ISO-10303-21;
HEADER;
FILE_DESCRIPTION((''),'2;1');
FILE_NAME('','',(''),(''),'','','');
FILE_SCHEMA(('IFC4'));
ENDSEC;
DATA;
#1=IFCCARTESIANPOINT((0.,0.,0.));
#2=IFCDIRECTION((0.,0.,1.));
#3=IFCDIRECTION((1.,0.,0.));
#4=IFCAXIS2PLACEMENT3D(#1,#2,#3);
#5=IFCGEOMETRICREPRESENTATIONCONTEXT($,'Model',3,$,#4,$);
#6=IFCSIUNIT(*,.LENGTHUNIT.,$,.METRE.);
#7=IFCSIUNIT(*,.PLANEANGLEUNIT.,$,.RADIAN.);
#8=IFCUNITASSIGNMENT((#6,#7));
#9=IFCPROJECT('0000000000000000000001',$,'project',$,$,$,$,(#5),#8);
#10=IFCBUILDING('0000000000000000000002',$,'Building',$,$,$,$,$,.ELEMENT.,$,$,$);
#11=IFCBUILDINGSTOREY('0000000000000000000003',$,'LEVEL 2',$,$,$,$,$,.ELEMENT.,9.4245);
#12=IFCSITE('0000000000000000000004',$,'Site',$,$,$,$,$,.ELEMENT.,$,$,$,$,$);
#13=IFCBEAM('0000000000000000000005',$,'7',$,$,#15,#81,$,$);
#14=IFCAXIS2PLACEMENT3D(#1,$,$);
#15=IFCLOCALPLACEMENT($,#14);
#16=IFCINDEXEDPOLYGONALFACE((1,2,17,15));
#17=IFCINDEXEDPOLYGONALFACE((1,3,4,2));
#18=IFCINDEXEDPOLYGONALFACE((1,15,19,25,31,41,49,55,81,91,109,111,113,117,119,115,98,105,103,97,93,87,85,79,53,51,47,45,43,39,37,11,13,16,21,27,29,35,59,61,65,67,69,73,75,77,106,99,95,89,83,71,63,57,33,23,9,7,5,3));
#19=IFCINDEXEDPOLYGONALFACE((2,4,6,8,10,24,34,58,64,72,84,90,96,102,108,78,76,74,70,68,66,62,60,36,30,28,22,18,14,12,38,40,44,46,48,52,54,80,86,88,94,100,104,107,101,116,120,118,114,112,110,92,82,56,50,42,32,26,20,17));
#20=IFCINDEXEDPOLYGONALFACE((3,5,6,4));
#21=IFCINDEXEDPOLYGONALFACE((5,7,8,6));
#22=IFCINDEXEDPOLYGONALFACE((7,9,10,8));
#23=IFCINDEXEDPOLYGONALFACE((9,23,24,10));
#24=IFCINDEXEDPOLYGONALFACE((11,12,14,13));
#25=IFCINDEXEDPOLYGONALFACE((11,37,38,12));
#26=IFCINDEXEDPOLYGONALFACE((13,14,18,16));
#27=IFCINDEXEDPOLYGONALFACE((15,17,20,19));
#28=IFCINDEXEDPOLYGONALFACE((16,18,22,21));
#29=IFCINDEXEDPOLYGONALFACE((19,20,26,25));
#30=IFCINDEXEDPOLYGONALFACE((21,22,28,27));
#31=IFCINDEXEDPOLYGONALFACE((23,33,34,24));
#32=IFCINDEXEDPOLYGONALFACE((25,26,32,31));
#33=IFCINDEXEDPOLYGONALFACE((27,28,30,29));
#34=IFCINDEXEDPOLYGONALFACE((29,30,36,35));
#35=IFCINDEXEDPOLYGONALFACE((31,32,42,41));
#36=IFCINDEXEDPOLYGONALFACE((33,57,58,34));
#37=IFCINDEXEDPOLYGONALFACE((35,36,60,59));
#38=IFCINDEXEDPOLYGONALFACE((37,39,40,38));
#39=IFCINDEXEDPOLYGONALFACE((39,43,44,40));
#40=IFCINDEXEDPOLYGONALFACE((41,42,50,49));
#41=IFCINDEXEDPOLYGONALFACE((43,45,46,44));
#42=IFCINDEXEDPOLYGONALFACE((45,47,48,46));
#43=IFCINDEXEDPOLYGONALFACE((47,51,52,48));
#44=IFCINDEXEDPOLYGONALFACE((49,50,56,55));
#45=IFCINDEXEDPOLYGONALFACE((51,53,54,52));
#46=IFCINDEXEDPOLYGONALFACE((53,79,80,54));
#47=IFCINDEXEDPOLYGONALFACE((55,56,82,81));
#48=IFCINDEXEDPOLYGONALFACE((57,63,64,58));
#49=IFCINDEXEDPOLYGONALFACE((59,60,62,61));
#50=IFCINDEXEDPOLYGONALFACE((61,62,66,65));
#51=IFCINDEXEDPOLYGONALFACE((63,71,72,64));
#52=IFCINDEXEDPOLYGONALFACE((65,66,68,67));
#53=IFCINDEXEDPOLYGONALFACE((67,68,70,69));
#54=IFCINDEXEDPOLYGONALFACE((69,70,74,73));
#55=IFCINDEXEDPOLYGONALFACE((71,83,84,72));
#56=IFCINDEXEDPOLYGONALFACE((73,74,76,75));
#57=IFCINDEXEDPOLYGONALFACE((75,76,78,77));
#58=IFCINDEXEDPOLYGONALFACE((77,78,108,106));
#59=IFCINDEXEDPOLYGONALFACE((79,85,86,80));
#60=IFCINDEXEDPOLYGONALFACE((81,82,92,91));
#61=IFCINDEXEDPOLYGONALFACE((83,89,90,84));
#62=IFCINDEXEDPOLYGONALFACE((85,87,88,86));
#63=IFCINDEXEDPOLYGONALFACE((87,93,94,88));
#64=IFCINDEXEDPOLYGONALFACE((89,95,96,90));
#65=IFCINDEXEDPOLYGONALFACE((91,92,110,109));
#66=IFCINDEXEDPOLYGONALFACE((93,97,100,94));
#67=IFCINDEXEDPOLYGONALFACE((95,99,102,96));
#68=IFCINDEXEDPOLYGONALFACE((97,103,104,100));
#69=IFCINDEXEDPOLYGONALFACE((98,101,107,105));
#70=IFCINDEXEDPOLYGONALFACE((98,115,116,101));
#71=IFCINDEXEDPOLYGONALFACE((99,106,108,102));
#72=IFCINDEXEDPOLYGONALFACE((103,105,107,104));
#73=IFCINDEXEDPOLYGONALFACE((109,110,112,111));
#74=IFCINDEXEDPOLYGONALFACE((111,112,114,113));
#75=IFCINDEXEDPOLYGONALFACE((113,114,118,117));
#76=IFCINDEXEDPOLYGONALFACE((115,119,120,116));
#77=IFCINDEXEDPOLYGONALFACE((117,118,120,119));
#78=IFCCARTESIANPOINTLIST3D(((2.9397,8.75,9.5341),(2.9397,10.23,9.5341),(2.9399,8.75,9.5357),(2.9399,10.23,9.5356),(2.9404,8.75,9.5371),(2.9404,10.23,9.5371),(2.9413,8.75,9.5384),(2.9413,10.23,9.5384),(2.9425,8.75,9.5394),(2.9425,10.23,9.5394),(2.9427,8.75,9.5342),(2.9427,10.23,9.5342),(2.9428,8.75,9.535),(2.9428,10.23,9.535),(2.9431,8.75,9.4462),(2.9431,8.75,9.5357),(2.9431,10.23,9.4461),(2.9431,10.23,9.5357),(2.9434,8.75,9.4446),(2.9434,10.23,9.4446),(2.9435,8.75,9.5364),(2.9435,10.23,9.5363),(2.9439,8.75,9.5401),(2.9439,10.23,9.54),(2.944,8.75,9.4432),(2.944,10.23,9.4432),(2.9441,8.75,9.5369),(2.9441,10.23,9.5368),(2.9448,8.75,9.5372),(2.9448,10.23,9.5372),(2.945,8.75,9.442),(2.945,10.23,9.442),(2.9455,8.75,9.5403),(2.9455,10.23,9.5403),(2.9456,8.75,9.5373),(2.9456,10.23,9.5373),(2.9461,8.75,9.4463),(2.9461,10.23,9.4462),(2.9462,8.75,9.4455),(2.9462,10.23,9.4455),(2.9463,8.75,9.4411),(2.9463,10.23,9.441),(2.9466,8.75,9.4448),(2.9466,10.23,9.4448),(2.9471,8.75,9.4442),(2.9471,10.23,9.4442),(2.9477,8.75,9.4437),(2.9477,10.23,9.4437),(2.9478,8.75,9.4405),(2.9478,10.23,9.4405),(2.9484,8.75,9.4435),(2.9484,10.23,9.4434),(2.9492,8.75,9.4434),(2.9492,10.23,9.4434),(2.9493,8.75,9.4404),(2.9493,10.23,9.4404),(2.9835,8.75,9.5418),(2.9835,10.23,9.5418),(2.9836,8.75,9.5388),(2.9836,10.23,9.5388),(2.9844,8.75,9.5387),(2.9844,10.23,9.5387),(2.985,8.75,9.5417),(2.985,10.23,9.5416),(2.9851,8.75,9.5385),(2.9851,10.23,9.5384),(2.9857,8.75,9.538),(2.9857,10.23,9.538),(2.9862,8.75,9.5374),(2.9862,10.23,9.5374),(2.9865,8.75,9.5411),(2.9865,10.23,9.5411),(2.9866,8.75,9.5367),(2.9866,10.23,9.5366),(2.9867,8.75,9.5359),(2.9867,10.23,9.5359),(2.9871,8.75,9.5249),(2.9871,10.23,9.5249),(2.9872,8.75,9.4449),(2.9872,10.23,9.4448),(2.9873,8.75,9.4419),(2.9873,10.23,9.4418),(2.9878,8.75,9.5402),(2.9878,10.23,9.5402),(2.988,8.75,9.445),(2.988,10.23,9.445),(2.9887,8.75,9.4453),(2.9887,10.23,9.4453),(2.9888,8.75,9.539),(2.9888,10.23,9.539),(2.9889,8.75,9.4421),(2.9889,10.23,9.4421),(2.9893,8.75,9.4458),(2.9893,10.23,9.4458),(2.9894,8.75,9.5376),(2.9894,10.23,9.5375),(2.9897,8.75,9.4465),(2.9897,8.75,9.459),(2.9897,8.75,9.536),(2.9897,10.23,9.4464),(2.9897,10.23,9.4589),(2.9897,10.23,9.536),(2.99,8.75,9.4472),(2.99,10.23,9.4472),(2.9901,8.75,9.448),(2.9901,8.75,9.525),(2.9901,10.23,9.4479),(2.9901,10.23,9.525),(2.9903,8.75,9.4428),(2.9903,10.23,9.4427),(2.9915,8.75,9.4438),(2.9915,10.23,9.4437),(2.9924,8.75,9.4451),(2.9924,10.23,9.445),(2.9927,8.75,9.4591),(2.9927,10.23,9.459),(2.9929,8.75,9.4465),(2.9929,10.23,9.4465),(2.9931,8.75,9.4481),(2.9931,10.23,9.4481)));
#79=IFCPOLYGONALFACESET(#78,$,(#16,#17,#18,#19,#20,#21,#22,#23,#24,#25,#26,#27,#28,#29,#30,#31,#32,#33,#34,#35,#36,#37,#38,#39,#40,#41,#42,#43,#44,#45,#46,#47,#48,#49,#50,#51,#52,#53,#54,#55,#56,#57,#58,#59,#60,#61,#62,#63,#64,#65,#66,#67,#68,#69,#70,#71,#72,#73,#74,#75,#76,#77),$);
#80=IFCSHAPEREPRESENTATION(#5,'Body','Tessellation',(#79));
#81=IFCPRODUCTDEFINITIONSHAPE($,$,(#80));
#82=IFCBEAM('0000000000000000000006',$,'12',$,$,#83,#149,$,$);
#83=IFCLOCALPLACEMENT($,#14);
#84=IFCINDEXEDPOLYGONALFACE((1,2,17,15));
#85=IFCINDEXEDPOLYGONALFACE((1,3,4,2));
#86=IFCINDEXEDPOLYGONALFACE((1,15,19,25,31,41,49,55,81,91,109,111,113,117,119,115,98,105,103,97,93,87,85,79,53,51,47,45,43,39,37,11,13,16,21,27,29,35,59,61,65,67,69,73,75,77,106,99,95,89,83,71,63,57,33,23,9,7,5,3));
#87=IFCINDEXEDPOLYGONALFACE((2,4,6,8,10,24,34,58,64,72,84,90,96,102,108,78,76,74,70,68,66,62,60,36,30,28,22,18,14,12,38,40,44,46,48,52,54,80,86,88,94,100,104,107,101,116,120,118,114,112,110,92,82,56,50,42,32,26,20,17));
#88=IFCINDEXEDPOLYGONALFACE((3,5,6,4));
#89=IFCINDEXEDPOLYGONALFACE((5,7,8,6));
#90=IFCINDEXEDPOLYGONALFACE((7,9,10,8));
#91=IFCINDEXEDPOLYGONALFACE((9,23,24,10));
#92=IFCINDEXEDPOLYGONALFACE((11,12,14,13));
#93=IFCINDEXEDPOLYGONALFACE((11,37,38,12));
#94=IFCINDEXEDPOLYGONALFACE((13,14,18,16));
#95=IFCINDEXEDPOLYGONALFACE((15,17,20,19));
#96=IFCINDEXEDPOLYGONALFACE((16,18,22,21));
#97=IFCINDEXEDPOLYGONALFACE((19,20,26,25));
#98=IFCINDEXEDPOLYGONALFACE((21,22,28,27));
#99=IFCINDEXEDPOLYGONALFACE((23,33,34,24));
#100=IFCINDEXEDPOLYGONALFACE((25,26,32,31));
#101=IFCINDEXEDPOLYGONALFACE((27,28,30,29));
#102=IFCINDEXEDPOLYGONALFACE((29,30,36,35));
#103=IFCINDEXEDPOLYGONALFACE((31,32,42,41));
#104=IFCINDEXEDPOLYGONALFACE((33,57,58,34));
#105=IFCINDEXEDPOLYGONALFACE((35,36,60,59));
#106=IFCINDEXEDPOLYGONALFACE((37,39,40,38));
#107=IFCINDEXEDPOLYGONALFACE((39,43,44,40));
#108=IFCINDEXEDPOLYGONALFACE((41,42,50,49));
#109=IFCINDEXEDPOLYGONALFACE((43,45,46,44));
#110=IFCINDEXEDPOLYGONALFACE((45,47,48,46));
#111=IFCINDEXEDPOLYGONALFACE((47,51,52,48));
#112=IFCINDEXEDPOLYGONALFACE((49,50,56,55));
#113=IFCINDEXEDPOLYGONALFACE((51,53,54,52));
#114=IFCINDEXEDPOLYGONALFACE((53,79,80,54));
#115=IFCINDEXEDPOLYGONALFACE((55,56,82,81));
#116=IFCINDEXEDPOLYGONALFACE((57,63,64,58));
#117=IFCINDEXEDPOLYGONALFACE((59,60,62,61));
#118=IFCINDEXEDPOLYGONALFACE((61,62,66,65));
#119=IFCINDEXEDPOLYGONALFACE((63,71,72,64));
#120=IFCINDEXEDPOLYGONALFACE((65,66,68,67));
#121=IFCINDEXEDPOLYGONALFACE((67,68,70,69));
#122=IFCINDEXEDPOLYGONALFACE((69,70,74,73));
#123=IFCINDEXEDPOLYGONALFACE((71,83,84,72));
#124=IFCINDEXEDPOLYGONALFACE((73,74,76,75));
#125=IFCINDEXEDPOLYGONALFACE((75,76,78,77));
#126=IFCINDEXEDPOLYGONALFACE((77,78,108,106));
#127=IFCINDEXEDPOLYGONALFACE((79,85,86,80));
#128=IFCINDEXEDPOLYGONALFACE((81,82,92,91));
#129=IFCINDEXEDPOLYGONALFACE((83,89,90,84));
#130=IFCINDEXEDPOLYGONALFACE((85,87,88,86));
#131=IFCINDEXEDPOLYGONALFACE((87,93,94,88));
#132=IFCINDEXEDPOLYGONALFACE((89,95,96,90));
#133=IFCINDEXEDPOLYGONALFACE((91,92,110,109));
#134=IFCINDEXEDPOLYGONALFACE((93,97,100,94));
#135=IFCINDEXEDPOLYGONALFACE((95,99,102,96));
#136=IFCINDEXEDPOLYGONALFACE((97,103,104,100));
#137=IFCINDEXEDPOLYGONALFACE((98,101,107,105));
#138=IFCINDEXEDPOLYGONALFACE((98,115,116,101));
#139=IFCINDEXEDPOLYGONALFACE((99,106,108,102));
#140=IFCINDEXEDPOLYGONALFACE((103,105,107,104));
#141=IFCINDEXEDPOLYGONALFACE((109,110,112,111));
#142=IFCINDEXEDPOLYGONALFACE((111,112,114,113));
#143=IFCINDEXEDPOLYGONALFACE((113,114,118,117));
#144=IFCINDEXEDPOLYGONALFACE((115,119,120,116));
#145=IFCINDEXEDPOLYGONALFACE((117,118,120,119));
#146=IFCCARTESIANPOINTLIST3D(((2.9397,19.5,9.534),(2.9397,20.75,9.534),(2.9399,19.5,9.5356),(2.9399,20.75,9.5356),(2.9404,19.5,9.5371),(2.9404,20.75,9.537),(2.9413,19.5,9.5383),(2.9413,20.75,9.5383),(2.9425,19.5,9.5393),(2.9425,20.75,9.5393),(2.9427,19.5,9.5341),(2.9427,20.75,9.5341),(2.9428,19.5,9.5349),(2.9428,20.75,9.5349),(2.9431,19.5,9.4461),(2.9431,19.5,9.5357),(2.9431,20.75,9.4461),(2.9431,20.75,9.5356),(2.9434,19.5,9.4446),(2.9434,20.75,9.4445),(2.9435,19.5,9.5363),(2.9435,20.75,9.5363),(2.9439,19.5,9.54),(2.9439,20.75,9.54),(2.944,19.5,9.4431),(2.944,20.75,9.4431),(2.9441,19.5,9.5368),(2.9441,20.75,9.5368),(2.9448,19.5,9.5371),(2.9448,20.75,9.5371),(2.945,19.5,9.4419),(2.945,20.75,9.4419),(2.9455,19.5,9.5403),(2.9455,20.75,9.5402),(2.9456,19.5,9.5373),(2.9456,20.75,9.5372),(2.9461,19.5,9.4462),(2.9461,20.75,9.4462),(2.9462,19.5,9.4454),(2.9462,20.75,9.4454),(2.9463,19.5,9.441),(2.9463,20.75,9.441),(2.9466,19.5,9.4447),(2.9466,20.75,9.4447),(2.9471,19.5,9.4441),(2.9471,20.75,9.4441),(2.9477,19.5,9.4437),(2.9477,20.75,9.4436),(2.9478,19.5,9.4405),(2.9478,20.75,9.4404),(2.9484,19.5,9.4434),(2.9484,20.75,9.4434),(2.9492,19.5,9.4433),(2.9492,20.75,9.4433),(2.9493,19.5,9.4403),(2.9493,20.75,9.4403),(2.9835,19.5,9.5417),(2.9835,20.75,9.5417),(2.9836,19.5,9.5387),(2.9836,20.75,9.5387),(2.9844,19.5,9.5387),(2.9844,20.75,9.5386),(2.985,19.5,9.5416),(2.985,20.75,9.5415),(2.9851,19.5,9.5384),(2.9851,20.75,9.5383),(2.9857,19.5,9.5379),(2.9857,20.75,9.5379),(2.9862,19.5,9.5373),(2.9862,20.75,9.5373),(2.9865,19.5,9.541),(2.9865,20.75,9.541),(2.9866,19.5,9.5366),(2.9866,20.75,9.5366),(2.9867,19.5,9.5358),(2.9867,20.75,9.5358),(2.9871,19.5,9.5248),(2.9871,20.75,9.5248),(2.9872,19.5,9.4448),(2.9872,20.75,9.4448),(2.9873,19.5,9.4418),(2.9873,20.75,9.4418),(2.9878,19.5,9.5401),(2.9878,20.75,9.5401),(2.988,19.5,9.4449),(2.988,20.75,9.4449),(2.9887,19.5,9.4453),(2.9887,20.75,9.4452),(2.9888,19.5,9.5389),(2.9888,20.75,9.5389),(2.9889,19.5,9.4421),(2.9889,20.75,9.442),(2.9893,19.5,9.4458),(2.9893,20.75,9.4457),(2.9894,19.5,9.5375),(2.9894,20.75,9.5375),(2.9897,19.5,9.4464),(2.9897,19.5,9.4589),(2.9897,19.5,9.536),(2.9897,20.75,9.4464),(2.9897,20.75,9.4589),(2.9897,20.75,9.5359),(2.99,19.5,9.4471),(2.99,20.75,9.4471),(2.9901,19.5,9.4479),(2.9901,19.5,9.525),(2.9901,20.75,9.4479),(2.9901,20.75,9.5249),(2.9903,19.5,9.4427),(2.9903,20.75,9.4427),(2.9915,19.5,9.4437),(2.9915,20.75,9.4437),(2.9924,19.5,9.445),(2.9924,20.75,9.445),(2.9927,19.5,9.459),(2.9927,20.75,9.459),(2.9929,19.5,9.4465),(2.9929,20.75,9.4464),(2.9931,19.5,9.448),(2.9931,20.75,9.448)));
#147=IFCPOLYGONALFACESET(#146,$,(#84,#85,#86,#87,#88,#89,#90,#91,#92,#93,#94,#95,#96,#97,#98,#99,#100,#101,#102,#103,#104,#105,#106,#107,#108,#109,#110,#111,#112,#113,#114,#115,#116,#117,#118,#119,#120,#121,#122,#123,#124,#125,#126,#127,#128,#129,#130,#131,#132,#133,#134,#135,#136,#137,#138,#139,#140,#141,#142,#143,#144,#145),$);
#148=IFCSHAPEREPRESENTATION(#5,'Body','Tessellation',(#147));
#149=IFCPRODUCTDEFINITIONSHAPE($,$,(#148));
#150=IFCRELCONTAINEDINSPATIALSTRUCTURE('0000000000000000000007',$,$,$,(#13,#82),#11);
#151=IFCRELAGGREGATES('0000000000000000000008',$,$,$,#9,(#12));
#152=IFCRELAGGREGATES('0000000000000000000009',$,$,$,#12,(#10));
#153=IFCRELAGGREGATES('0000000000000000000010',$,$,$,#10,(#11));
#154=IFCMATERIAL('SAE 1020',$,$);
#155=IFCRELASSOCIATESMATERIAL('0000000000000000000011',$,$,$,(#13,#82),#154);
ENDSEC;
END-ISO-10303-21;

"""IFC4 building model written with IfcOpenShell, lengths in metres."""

from ifc_helpers import new_model, si_unit, frame, origin_with_axes, origin_2d_with_axis, place, context, project, spatial, c_section, extrude, material, material_profile, profile_set, profile_usage, element, save


model = new_model("IFC4")

# Units and contexts
model_context = context("Model", 3, world=origin_with_axes())
ifc_project = project(units=[si_unit("LENGTHUNIT", "METRE"), si_unit("PLANEANGLEUNIT", "RADIAN")], contexts=[model_context])

# Site, building, storey
site = spatial("IfcSite", under=ifc_project, Name="Site", CompositionType="ELEMENT")
building = spatial("IfcBuilding", under=site, Name="Building", CompositionType="ELEMENT")
storey = spatial("IfcBuildingStorey", under=building, Name="LEVEL 2", CompositionType="ELEMENT", Elevation=9.4245)

# Beams
ifc_material = material(Name="SAE 1020")
ifc_material_profile_1 = material_profile(ifc_material, c_section(Depth=0.1, Width=0.05, WallThickness=0.003, Girth=0.017, InternalFilletRadius=0.003, at=origin_2d_with_axis()))
ifc_profile_set_1 = profile_set([ifc_material_profile_1])
ifc_profile_usage_1 = profile_usage(ifc_profile_set_1, cardinal=10)
beam_1_placement = place(None, frame((2.9664, 8.75, 9.4911), z_axis=(0.0, 1.0, -0.00003), x_axis=(0.999256, 0.000001, 0.038562)))
element("IfcBeam", 1, at=beam_1_placement, inside=storey, material=ifc_profile_usage_1, Name="7", context=model_context, shape_type="SweptSolid", body=[
    extrude(c_section(Depth=0.1, Width=0.05, WallThickness=0.003, Girth=0.017, InternalFilletRadius=0.003, at=origin_2d_with_axis()), origin_with_axes(), (0.0, 0.0, 1.0), 1.48),
])
ifc_material_profile_2 = material_profile(ifc_material, c_section(Depth=0.1, Width=0.05, WallThickness=0.003, Girth=0.017, InternalFilletRadius=0.003, at=origin_2d_with_axis()))
ifc_profile_set_2 = profile_set([ifc_material_profile_2])
ifc_profile_usage_2 = profile_usage(ifc_profile_set_2, cardinal=10)
beam_2_placement = place(None, frame((2.9664, 19.5, 9.491), z_axis=(0.0, 1.0, -0.00003), x_axis=(0.999256, 0.000001, 0.038562)))
element("IfcBeam", 2, at=beam_2_placement, inside=storey, material=ifc_profile_usage_2, Name="12", context=model_context, shape_type="SweptSolid", body=[
    extrude(c_section(Depth=0.1, Width=0.05, WallThickness=0.003, Girth=0.017, InternalFilletRadius=0.003, at=origin_2d_with_axis()), origin_with_axes(), (0.0, 0.0, 1.0), 1.25),
])

save(model, "model.ifc")
